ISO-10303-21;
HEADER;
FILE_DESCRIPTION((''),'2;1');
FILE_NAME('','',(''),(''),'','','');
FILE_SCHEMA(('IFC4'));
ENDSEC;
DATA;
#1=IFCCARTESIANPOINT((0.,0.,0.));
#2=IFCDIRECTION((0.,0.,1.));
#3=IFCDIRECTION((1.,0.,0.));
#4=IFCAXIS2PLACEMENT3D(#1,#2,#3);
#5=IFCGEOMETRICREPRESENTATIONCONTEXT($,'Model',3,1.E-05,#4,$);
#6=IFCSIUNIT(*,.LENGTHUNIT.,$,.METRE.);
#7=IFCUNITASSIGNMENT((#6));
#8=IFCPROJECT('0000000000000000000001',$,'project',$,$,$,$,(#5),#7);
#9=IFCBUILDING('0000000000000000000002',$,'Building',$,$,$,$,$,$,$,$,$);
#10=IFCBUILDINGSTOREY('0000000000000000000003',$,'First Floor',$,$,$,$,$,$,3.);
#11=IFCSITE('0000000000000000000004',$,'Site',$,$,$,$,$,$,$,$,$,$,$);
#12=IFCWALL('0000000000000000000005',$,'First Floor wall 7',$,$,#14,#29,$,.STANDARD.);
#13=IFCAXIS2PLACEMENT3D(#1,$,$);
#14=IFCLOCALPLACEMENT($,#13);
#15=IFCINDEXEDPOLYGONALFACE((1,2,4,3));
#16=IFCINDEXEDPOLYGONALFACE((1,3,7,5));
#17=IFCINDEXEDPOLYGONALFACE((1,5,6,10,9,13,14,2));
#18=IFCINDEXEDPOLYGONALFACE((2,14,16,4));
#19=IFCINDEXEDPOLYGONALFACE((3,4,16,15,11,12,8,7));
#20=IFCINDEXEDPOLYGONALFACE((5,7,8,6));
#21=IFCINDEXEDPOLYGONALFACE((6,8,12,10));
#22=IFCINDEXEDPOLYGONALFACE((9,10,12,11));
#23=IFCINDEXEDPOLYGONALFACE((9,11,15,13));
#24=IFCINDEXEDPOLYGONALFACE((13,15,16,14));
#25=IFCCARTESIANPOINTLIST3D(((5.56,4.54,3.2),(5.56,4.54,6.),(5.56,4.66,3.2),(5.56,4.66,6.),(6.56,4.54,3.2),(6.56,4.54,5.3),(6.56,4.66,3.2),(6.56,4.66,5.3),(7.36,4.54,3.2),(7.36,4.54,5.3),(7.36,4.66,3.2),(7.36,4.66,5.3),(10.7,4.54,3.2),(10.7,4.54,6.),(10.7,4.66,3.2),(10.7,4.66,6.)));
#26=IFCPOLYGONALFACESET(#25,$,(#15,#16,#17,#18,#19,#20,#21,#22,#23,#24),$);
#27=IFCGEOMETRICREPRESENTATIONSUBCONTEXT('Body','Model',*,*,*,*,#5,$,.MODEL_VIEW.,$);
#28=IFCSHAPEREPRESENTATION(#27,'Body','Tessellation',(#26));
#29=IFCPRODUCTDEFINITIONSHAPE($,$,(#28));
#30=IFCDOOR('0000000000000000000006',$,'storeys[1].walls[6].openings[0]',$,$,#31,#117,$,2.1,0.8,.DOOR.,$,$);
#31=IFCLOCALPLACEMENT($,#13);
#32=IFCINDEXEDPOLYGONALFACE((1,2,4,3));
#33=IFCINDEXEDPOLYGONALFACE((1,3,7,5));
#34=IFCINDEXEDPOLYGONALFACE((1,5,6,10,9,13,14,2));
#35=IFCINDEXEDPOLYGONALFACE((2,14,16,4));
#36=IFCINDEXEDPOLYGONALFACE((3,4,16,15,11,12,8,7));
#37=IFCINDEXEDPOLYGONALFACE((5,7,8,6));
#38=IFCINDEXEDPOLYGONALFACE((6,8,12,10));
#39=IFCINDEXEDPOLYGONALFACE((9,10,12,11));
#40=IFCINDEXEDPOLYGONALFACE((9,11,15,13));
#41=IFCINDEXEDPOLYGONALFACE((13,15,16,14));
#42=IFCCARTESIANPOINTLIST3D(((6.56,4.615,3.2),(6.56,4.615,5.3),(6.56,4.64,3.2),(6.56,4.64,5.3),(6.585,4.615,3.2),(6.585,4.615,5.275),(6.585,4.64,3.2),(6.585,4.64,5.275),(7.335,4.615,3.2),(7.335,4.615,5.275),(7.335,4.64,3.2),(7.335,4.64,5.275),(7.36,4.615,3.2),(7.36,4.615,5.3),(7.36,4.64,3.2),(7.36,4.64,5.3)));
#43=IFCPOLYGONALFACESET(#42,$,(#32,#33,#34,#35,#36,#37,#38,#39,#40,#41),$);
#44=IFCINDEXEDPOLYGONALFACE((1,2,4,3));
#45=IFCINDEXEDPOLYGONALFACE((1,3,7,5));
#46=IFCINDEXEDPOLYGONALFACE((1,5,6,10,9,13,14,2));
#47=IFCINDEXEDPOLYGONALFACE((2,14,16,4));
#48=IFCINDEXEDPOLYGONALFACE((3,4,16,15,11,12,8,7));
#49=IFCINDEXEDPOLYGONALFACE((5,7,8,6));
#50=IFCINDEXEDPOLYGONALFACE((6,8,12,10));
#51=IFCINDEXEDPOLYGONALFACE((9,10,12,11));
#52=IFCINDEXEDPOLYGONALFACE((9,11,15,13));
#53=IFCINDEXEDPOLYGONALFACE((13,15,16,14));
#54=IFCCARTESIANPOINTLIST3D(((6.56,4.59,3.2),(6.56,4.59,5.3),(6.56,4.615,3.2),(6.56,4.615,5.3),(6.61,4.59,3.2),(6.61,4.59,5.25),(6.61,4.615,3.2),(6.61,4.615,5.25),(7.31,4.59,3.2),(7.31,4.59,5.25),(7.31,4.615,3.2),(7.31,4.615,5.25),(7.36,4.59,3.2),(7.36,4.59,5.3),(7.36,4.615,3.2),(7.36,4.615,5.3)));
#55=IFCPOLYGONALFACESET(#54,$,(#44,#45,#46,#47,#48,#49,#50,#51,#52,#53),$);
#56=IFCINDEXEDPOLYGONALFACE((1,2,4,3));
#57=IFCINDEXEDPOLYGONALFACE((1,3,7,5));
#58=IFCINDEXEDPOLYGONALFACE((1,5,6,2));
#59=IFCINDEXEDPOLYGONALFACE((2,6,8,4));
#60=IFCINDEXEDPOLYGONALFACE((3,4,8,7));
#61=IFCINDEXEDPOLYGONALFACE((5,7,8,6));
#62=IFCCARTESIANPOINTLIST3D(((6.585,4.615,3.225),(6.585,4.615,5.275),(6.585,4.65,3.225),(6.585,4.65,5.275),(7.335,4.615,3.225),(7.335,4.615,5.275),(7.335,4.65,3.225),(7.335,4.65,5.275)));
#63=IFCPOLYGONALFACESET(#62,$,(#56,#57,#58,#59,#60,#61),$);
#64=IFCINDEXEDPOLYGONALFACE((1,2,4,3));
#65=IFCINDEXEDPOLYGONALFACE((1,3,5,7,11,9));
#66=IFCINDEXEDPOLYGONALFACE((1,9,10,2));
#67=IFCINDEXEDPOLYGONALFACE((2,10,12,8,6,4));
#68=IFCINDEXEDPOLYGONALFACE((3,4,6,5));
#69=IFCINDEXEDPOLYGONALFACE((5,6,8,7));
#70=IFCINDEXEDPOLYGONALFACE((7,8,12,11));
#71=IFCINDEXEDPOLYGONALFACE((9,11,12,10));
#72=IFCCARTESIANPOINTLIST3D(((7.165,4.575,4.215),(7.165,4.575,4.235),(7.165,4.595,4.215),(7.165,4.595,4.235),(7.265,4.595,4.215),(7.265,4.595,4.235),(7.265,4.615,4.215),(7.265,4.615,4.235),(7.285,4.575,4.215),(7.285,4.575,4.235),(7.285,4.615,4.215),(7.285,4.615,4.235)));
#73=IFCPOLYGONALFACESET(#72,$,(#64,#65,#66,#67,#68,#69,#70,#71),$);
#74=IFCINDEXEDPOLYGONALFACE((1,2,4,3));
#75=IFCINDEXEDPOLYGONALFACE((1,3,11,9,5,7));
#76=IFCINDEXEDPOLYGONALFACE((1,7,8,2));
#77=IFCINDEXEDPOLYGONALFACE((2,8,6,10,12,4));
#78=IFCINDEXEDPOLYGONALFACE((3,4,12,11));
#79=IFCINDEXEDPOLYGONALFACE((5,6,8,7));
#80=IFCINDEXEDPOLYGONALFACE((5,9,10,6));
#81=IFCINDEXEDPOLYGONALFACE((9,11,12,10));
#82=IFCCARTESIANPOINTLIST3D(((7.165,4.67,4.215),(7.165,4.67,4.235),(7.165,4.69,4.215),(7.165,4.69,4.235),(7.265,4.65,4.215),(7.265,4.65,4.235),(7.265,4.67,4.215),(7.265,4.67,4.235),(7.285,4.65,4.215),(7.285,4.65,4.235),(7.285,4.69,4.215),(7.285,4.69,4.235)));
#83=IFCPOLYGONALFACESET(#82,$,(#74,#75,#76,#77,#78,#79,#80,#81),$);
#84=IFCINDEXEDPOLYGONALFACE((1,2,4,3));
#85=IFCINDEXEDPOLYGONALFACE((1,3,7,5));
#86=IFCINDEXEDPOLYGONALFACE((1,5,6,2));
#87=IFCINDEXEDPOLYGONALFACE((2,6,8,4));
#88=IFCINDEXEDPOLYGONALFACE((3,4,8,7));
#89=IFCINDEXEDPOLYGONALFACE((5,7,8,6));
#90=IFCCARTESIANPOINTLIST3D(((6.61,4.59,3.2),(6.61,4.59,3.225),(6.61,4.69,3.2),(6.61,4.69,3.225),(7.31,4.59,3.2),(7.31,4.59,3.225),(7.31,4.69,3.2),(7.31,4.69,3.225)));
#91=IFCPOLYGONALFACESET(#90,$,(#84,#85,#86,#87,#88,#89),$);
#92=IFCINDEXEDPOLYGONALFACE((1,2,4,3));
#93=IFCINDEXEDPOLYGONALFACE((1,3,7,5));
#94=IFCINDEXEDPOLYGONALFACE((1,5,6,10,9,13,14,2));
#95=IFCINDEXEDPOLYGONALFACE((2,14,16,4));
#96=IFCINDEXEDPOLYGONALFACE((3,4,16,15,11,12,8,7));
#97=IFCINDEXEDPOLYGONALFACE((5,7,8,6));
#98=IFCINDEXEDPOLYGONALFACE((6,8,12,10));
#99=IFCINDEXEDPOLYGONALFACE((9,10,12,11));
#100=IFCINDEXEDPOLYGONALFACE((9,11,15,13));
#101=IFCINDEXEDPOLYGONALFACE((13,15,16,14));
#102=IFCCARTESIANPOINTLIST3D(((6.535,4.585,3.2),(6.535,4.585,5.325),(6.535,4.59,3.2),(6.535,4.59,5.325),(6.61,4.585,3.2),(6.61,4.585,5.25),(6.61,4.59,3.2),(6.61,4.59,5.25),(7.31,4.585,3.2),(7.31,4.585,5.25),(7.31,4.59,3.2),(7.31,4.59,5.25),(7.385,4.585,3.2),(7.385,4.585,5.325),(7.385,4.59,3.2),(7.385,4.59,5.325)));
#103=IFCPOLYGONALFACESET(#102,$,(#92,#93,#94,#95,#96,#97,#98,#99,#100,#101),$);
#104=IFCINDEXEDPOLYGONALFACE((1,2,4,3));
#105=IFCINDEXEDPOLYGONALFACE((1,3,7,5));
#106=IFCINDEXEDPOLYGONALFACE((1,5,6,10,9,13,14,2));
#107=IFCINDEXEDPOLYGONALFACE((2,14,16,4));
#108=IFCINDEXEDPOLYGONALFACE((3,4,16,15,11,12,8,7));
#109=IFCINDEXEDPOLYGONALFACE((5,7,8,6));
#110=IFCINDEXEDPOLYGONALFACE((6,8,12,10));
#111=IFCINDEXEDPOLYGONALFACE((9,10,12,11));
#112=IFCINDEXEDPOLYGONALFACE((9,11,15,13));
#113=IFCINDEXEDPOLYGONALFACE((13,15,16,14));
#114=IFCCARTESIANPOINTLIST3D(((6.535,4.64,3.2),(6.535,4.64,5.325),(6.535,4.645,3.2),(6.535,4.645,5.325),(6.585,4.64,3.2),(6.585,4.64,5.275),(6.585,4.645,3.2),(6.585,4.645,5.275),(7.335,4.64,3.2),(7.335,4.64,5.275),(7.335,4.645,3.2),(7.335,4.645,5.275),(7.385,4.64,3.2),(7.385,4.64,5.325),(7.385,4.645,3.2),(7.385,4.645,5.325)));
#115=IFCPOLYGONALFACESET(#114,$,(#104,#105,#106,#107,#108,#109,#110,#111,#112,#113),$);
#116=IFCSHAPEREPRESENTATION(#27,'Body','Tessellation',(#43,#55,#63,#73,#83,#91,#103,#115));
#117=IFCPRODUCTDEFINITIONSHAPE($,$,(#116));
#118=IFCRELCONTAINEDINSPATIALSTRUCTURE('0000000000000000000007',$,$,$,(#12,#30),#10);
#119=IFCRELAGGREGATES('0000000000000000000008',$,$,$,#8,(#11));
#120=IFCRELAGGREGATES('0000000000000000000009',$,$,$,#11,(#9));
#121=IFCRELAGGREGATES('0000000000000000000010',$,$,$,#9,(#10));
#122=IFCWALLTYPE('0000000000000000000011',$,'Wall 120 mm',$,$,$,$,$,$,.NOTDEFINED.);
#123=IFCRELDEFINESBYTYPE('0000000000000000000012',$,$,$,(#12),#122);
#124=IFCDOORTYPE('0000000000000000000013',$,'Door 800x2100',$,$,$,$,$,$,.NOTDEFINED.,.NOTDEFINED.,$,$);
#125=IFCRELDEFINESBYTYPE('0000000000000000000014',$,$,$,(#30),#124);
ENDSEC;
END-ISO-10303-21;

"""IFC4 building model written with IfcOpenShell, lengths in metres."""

from ifc_helpers import new_model, si_unit, frame, origin_with_axes, place, context, subcontext, project, spatial, line, indexed_curve, outline, extrude, type_object, element, fill, save


model = new_model("IFC4")

# Units and contexts
model_context = context("Model", 3, precision=1e-05, world=origin_with_axes())
body_context = subcontext(model_context, "Body", "Model", "MODEL_VIEW")
ifc_project = project(units=[si_unit("LENGTHUNIT", "METRE")], contexts=[model_context])

# Site, building, storey
site = spatial("IfcSite", under=ifc_project, Name="Site")
building = spatial("IfcBuilding", under=site, Name="Building")
storey = spatial("IfcBuildingStorey", under=building, Name="First Floor", Elevation=3.0)

# Shared definitions
wall_type_1 = type_object("IfcWallType", Name="Wall 120 mm", PredefinedType="NOTDEFINED")

# Wall, opening, door
wall_1_placement = place(None, frame((5.56, 4.6, 3.2), z_axis=(0.0, 0.0, 1.0), x_axis=(1.0, 0.0, 0.0)))
wall_1 = element("IfcWall", 1, at=wall_1_placement, inside=storey, type_object=wall_type_1, Name="First Floor wall 7", PredefinedType="STANDARD", context=body_context, shape_type="SweptSolid", body=[
    extrude(outline(indexed_curve([(0.0, 0.0), (0.0, 0.12), (5.14, 0.12), (5.14, 0.0), (0.0, 0.0)], self_intersect=False)), frame((0.0, -0.06, 0.0), z_axis=(0.0, 0.0, 1.0), x_axis=(1.0, 0.0, 0.0)), (0.0, 0.0, 1.0), 2.8),
])
opening_1_placement = place(wall_1_placement, frame((1.0, -0.07, 0.0), z_axis=(0.0, 0.0, 1.0), x_axis=(1.0, 0.0, 0.0)))
opening_1 = element("IfcOpeningElement", 2, at=opening_1_placement, cuts=wall_1, context=body_context, shape_type="SweptSolid", body=[
    extrude(outline(indexed_curve([(0.0, 0.0), (0.0, 0.14), (0.8, 0.14), (0.8, 0.0), (0.0, 0.0)], self_intersect=False)), origin_with_axes(), (0.0, 0.0, 1.0), 2.1),
])
door_type_1 = type_object("IfcDoorType", Name="Door 800x2100", OperationType="NOTDEFINED", PredefinedType="NOTDEFINED")
door_1_placement = place(None, frame((6.56, 4.59, 3.2), z_axis=(0.0, 0.0, 1.0), x_axis=(1.0, 0.0, 0.0)))
door_1 = element("IfcDoor", 3, at=door_1_placement, inside=storey, type_object=door_type_1, Name="storeys[1].walls[6].openings[0]", OverallHeight=2.1, OverallWidth=0.8, PredefinedType="DOOR", context=body_context, shape_type="SweptSolid", body=[
    extrude(outline(indexed_curve([(0.0, 0.0), (0.0, 2.1), (0.8, 2.1), (0.8, 0.0), (0.775, 0.0), (0.775, 2.075), (0.025, 2.075), (0.025, 0.0)], segments=[line(1, 2, 3, 4, 5, 6, 7, 8, 1)])), frame((0.0, 0.025, 0.0), z_axis=(0.0, -1.0, 0.0), x_axis=(1.0, 0.0, 0.0)), (0.0, 0.0, -1.0), 0.025),
    extrude(outline(indexed_curve([(0.0, 0.0), (0.0, 2.1), (0.8, 2.1), (0.8, 0.0), (0.75, 0.0), (0.75, 2.05), (0.05, 2.05), (0.05, 0.0)], segments=[line(1, 2, 3, 4, 5, 6, 7, 8, 1)])), frame((0.0, 0.0, 0.0), z_axis=(0.0, -1.0, 0.0), x_axis=(1.0, 0.0, 0.0)), (0.0, 0.0, -1.0), 0.025),
    extrude(outline(indexed_curve([(0.0, 0.0), (0.75, 0.0), (0.75, 0.035), (0.0, 0.035)], segments=[line(1, 2, 3, 4, 1)])), frame((0.025, 0.025, 0.025), z_axis=(0.0, 0.0, 1.0), x_axis=(1.0, 0.0, 0.0)), (0.0, 0.0, 1.0), 2.05),
    extrude(outline(indexed_curve([(0.0, 0.0), (0.0, -0.04), (-0.12, -0.04), (-0.12, -0.02), (-0.02, -0.02), (-0.02, 0.0)], segments=[line(1, 2, 3, 4, 5, 6, 1)])), frame((0.725, 0.025, 1.015), z_axis=(0.0, 0.0, 1.0), x_axis=(1.0, 0.0, 0.0)), (0.0, 0.0, 1.0), 0.02),
    extrude(outline(indexed_curve([(0.0, 0.0), (0.0, 0.04), (-0.12, 0.04), (-0.12, 0.02), (-0.02, 0.02), (-0.02, 0.0)], segments=[line(1, 2, 3, 4, 5, 6, 1)])), frame((0.725, 0.06, 1.015), z_axis=(0.0, 0.0, 1.0), x_axis=(1.0, 0.0, 0.0)), (0.0, 0.0, 1.0), 0.02),
    extrude(outline(indexed_curve([(0.0, 0.0), (0.7, 0.0), (0.7, 0.1), (0.0, 0.1)], segments=[line(1, 2, 3, 4, 1)])), frame((0.05, 0.0, 0.0), z_axis=(0.0, 0.0, 1.0), x_axis=(1.0, 0.0, 0.0)), (0.0, 0.0, 1.0), 0.025),
    extrude(outline(indexed_curve([(0.0, 0.0), (0.0, 2.125), (0.85, 2.125), (0.85, 0.0), (0.775, 0.0), (0.775, 2.05), (0.075, 2.05), (0.075, 0.0)], segments=[line(1, 2, 3, 4, 5, 6, 7, 8, 1)])), frame((-0.025, -0.005, 0.0), z_axis=(0.0, -1.0, 0.0), x_axis=(1.0, 0.0, 0.0)), (0.0, 0.0, -1.0), 0.005),
    extrude(outline(indexed_curve([(0.0, 0.0), (0.0, 2.125), (0.85, 2.125), (0.85, 0.0), (0.8, 0.0), (0.8, 2.075), (0.05, 2.075), (0.05, 0.0)], segments=[line(1, 2, 3, 4, 5, 6, 7, 8, 1)])), frame((-0.025, 0.05, 0.0), z_axis=(0.0, -1.0, 0.0), x_axis=(1.0, 0.0, 0.0)), (0.0, 0.0, -1.0), 0.005),
])
fill(opening_1, door_1)

save(model, "model.ifc")
